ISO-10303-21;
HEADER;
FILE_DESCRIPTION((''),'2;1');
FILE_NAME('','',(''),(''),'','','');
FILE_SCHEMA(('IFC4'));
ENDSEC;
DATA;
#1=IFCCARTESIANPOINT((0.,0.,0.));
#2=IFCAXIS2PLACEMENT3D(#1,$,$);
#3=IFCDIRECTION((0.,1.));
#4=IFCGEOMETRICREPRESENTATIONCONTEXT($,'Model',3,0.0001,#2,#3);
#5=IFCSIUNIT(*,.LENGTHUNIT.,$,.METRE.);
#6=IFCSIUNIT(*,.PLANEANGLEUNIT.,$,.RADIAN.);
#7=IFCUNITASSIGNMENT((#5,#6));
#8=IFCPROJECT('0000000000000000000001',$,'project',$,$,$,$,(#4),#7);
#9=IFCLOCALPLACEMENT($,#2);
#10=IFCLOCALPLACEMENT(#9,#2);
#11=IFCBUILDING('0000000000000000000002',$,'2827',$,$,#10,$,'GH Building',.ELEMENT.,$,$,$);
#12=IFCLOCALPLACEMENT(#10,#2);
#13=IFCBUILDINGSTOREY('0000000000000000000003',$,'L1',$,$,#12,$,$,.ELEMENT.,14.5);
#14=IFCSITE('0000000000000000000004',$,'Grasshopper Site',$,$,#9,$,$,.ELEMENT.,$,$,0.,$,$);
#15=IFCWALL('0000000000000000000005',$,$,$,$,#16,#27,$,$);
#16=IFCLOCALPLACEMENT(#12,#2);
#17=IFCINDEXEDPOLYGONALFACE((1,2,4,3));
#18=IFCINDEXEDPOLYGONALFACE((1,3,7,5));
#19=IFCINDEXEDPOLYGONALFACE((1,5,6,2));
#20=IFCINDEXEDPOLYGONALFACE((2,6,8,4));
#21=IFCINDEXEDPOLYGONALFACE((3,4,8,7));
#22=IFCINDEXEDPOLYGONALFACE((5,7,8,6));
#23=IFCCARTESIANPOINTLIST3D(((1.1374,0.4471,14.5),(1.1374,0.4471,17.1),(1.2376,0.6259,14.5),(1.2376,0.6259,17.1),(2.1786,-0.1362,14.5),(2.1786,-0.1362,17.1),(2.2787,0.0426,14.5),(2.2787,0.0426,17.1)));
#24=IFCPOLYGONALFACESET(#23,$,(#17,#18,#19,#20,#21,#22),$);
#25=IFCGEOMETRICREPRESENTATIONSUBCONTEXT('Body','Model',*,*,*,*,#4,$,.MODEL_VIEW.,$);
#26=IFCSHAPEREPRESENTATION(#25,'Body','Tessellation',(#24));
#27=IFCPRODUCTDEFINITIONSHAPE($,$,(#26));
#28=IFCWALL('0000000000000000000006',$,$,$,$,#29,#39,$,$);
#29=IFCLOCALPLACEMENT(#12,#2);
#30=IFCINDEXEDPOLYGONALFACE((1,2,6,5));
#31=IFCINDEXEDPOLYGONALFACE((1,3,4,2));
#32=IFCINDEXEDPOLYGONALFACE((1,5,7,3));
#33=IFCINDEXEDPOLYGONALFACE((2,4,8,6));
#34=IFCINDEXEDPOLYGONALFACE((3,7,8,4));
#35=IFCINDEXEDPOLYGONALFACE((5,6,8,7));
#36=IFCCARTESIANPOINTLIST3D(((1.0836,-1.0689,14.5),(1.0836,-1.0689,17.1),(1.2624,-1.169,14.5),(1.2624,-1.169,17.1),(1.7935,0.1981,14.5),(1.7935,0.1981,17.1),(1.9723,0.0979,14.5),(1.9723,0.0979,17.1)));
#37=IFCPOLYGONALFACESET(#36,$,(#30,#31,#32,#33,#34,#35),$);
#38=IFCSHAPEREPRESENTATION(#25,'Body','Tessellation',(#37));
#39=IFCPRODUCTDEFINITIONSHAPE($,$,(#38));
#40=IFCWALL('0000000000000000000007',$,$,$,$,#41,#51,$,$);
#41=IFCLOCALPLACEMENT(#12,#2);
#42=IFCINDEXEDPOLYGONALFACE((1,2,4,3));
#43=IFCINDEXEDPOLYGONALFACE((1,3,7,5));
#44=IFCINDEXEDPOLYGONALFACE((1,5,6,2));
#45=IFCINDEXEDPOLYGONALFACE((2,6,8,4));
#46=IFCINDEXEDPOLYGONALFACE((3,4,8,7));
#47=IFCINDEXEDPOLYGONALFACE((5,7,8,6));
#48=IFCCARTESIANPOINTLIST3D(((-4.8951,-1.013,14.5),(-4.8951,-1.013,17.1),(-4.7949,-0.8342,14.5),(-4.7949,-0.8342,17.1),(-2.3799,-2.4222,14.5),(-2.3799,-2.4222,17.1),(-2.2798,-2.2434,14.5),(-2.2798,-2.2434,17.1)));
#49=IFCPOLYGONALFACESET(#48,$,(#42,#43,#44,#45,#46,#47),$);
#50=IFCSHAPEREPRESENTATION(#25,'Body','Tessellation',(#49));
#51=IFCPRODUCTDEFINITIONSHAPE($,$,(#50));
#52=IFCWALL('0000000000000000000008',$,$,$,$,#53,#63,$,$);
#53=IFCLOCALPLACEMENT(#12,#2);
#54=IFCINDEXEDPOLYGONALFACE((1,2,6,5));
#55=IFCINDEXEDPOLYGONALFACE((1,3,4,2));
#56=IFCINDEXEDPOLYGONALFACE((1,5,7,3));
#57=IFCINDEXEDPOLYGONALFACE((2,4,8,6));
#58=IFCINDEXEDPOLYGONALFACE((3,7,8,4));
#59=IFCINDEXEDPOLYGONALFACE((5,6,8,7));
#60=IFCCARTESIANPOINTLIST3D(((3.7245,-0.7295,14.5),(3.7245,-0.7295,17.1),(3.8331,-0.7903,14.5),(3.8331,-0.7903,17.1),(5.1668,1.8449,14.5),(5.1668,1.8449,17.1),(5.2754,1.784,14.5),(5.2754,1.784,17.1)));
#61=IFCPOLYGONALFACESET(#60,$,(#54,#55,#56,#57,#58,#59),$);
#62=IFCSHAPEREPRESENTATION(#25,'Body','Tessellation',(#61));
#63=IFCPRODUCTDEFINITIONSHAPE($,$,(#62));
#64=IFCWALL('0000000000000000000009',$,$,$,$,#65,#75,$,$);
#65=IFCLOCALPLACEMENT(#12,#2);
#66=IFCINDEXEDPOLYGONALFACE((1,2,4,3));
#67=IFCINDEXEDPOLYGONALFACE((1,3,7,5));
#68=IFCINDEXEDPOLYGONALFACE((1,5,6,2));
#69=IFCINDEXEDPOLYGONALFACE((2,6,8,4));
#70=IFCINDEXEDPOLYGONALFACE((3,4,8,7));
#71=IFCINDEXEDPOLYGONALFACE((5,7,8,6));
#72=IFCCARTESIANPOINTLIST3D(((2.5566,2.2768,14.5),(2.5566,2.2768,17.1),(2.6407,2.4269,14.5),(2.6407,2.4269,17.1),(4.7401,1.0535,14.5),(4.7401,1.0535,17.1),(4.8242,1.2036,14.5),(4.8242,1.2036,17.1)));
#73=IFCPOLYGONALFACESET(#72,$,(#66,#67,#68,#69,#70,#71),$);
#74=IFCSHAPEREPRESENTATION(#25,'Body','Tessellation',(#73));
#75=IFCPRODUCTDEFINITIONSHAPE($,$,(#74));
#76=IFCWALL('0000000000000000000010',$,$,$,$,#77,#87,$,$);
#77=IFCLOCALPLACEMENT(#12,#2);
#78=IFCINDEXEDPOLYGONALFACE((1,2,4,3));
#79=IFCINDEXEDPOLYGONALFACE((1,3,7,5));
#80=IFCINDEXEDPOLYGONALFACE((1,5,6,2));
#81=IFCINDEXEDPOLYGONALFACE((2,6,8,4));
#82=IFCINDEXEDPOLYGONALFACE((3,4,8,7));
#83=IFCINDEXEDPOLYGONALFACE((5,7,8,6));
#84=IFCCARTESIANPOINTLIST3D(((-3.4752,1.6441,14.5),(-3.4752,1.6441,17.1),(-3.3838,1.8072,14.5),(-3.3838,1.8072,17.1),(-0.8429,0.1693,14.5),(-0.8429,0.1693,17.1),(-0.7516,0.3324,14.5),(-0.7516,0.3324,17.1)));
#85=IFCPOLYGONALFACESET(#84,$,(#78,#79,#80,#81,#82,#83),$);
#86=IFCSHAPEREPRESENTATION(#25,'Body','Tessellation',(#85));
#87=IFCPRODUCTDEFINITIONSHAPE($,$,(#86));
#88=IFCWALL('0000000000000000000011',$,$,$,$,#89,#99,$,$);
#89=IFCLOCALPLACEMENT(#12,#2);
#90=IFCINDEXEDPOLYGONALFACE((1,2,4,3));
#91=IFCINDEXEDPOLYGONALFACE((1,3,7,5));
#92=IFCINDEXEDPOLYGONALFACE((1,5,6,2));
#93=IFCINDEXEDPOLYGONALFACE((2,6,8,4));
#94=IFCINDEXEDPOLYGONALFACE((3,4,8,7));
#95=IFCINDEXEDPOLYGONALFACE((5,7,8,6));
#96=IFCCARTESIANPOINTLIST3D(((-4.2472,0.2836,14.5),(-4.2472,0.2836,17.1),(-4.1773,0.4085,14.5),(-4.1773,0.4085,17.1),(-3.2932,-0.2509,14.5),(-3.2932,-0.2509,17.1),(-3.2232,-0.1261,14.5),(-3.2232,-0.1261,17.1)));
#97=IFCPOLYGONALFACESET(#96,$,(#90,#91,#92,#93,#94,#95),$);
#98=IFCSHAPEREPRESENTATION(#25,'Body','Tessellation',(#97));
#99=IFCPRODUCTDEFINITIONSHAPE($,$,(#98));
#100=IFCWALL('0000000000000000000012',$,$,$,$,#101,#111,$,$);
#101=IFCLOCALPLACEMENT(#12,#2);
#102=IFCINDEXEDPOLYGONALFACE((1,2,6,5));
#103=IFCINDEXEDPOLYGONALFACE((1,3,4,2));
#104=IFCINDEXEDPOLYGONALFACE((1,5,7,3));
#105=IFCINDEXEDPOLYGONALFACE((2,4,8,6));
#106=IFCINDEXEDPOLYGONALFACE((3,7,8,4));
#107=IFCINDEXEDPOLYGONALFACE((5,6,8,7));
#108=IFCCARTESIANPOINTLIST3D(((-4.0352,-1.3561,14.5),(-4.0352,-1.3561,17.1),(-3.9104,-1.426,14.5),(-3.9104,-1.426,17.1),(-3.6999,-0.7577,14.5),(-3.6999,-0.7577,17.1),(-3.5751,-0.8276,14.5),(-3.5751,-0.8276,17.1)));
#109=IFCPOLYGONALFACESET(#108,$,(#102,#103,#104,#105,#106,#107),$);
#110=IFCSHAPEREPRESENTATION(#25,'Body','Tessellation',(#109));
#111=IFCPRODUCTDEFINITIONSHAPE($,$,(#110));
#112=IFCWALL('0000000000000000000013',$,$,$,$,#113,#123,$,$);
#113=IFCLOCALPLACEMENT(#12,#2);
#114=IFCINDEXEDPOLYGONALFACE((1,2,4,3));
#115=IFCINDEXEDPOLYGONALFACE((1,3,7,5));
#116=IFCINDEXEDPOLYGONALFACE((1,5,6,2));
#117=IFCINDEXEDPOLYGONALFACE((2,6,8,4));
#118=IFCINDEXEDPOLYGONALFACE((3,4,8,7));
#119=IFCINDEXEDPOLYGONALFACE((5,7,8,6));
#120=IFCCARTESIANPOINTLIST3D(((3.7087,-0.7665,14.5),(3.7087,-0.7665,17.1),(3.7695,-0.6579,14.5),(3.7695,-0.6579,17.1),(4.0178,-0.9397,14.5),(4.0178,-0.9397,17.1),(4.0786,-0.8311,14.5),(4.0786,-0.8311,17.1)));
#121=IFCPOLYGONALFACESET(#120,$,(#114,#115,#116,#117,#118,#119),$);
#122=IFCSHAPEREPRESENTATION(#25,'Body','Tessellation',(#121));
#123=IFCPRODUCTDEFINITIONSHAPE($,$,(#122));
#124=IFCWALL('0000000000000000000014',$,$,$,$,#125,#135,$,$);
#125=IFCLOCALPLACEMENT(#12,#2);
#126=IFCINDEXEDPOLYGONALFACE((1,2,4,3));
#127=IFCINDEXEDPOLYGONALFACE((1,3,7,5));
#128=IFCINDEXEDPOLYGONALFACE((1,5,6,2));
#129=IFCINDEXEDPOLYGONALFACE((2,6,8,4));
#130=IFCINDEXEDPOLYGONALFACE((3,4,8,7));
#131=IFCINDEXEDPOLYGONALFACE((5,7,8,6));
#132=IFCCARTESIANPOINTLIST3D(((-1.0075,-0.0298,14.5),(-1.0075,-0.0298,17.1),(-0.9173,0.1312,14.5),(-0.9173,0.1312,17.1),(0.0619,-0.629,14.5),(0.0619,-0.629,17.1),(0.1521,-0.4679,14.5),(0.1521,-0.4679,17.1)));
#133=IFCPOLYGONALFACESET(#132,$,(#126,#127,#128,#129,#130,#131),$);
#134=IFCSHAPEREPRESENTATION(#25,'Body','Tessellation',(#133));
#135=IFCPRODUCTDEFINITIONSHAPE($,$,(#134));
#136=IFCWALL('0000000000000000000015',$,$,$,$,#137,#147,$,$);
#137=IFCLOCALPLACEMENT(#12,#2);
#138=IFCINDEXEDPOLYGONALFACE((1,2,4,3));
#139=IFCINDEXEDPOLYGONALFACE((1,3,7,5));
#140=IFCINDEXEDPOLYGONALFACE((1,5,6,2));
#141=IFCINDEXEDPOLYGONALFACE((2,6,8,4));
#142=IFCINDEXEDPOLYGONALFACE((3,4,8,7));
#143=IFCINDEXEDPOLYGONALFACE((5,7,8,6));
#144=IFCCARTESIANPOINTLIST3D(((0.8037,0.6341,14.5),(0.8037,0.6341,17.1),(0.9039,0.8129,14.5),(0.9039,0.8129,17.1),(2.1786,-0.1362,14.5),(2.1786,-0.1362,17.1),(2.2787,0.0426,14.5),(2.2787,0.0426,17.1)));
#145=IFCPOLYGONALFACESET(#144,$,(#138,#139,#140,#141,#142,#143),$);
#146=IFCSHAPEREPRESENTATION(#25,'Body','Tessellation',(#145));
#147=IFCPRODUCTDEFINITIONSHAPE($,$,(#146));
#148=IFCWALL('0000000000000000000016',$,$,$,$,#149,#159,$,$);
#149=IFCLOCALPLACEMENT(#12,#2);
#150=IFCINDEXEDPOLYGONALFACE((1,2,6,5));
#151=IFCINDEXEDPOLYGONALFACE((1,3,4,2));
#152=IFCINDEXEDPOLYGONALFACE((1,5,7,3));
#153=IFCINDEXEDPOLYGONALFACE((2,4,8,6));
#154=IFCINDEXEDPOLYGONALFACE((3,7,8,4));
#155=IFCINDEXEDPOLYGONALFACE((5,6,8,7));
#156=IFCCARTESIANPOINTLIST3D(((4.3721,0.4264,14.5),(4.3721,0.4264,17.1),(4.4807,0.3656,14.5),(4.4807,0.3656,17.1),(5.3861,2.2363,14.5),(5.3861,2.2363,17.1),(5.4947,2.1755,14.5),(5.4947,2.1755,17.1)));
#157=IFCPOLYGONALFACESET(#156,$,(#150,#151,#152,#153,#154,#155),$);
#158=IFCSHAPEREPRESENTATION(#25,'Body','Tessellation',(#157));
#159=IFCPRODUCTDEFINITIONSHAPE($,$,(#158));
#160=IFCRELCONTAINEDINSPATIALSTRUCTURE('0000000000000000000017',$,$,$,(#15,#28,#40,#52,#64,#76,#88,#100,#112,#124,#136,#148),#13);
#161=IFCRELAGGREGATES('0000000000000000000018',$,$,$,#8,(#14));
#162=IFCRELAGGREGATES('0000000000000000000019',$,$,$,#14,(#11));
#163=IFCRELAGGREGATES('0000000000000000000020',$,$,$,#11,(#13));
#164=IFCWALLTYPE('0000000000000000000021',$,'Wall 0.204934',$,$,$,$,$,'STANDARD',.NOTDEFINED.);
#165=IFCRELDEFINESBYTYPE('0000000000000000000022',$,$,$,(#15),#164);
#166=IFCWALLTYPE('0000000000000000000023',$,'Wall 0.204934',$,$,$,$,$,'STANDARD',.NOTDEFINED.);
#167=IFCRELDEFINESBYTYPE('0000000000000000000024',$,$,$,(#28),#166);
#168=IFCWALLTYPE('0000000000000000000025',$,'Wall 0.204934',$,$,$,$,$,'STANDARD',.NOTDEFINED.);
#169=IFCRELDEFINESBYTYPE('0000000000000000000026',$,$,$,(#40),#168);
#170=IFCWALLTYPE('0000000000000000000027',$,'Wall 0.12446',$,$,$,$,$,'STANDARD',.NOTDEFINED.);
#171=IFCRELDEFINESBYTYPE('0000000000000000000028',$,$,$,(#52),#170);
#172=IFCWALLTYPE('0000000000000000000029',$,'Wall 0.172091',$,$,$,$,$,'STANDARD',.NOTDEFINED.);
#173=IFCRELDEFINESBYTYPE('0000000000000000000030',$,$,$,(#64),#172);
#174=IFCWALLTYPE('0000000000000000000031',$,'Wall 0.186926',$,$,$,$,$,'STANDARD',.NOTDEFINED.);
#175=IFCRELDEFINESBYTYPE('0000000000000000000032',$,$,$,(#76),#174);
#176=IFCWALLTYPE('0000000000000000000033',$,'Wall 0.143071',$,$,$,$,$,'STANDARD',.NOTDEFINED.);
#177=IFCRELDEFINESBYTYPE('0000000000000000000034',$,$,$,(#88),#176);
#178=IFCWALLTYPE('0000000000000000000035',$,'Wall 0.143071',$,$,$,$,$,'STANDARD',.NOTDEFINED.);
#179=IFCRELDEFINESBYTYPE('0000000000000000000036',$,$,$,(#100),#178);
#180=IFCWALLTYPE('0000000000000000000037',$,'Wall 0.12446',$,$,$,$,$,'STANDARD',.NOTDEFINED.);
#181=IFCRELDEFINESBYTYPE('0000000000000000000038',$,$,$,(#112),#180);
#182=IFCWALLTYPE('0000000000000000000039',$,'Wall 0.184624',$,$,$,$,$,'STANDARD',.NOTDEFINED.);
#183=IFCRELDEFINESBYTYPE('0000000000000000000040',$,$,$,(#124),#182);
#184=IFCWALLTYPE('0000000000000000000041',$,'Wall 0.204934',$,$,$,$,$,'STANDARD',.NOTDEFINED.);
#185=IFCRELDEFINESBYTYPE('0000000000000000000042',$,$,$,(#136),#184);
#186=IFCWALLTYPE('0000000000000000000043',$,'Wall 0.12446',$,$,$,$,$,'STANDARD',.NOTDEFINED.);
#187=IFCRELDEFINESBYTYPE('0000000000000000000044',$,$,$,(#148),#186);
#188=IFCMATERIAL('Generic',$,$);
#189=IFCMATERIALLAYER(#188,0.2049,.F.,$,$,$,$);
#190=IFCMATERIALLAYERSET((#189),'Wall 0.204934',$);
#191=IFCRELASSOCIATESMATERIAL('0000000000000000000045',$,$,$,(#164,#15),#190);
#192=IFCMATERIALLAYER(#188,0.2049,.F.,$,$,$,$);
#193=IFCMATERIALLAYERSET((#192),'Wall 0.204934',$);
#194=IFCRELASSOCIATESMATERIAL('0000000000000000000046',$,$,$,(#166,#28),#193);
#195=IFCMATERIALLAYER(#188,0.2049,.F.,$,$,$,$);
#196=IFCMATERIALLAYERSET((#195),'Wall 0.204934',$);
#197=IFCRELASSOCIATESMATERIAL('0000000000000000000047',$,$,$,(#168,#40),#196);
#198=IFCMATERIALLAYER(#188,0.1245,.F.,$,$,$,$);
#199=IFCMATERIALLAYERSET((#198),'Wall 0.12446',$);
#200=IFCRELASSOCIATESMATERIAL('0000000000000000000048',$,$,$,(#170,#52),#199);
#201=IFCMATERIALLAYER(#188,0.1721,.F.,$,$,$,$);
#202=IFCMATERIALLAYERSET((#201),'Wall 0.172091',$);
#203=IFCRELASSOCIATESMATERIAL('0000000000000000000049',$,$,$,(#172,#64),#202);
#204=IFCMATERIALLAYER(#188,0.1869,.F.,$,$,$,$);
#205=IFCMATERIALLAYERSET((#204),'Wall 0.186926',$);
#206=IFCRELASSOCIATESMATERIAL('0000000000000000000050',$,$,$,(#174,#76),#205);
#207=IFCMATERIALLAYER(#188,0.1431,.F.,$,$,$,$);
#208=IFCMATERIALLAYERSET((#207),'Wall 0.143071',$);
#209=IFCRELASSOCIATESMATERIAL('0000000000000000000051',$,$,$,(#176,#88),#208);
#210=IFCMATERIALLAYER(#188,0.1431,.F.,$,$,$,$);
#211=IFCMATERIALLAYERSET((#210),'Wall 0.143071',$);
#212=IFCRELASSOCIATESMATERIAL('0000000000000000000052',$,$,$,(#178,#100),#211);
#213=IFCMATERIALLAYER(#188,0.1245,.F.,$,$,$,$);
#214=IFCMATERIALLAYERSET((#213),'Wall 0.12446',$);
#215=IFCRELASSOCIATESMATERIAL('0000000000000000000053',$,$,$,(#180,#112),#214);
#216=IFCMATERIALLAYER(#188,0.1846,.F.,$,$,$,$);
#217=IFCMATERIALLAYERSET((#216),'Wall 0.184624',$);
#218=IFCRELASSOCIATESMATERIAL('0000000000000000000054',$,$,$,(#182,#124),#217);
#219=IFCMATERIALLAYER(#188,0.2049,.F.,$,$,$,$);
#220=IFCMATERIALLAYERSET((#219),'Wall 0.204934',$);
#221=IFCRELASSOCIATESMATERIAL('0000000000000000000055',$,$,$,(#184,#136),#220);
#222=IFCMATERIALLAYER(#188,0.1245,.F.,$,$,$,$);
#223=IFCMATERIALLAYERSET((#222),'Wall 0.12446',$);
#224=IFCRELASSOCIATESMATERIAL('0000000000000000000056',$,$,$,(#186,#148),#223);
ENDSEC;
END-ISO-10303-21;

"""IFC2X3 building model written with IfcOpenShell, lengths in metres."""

from ifc_helpers import new_model, si_unit, direction, frame, frame_2d, origin, place, context, subcontext, project, spatial, rectangle, extrude, material, layer, layer_set, layer_usage, type_object, element, save


model = new_model("IFC2X3")

# Units and contexts
model_context = context("Model", 3, precision=0.0001, world=origin(), true_north=direction((0.0, 1.0)))
body_context = subcontext(model_context, "Body", "Model", "MODEL_VIEW")
ifc_project = project(units=[si_unit("LENGTHUNIT", "METRE"), si_unit("PLANEANGLEUNIT", "RADIAN")], contexts=[model_context])

# Site, building, storey
site_placement = place(None, origin())
site = spatial("IfcSite", under=ifc_project, at=site_placement, Name="Grasshopper Site", CompositionType="ELEMENT", RefElevation=0.0)
building_placement = place(site_placement, origin())
building = spatial("IfcBuilding", under=site, at=building_placement, Name="2827", LongName="GH Building", CompositionType="ELEMENT")
storey_placement = place(building_placement, origin())
storey = spatial("IfcBuildingStorey", under=building, at=storey_placement, Name="L1", CompositionType="ELEMENT", Elevation=14.5)

# Wall
ifc_material = material(Name="Generic")
ifc_layer_1 = layer(ifc_material, 0.2049, ventilated=False)
ifc_layer_set_1 = layer_set([ifc_layer_1], Name="Wall 0.204934")
ifc_layer_usage_1 = layer_usage(ifc_layer_set_1, "AXIS2", "NEGATIVE", 0.1025)
wall_type_1 = type_object("IfcWallType", Name="Wall 0.204934", ElementType="STANDARD", PredefinedType="NOTDEFINED", material=ifc_layer_set_1)
wall_1_placement = place(storey_placement, frame((1.1875, 0.5365, 14.5), z_axis=(0.0, 0.0, 1.0), x_axis=(0.872406, -0.488782, 0.0)))
element("IfcWall", 1, at=wall_1_placement, inside=storey, type_object=wall_type_1, material=ifc_layer_usage_1, context=body_context, shape_type="SweptSolid", body=[
    extrude(rectangle(XDim=1.1934, YDim=0.2049, at=frame_2d((0.5967, 0.0))), origin(), (0.0, 0.0, 1.0), 2.6),
])

# Walls
ifc_layer_2 = layer(ifc_material, 0.2049, ventilated=False)
ifc_layer_set_2 = layer_set([ifc_layer_2], Name="Wall 0.204934")
ifc_layer_usage_2 = layer_usage(ifc_layer_set_2, "AXIS2", "NEGATIVE", 0.1025)
wall_type_2 = type_object("IfcWallType", Name="Wall 0.204934", ElementType="STANDARD", PredefinedType="NOTDEFINED", material=ifc_layer_set_2)
wall_2_placement = place(storey_placement, frame((1.8829, 0.148, 14.5), z_axis=(0.0, 0.0, 1.0), x_axis=(-0.488782, -0.872406, 0.0)))
element("IfcWall", 2, at=wall_2_placement, inside=storey, type_object=wall_type_2, material=ifc_layer_usage_2, context=body_context, shape_type="SweptSolid", body=[
    extrude(rectangle(XDim=1.4523, YDim=0.2049, at=frame_2d((0.7261, 0.0))), origin(), (0.0, 0.0, 1.0), 2.6),
])
ifc_layer_3 = layer(ifc_material, 0.2049, ventilated=False)
ifc_layer_set_3 = layer_set([ifc_layer_3], Name="Wall 0.204934")
ifc_layer_usage_3 = layer_usage(ifc_layer_set_3, "AXIS2", "NEGATIVE", 0.1025)
wall_type_3 = type_object("IfcWallType", Name="Wall 0.204934", ElementType="STANDARD", PredefinedType="NOTDEFINED", material=ifc_layer_set_3)
wall_3_placement = place(storey_placement, frame((-4.845, -0.9236, 14.5), z_axis=(0.0, 0.0, 1.0), x_axis=(0.872406, -0.488782, 0.0)))
element("IfcWall", 3, at=wall_3_placement, inside=storey, type_object=wall_type_3, material=ifc_layer_usage_3, context=body_context, shape_type="SweptSolid", body=[
    extrude(rectangle(XDim=2.883, YDim=0.2049, at=frame_2d((1.4415, 0.0))), origin(), (0.0, 0.0, 1.0), 2.6),
])

# Wall
ifc_layer_4 = layer(ifc_material, 0.1245, ventilated=False)
ifc_layer_set_4 = layer_set([ifc_layer_4], Name="Wall 0.12446")
ifc_layer_usage_4 = layer_usage(ifc_layer_set_4, "AXIS2", "NEGATIVE", 0.0622)
wall_type_4 = type_object("IfcWallType", Name="Wall 0.12446", ElementType="STANDARD", PredefinedType="NOTDEFINED", material=ifc_layer_set_4)
wall_4_placement = place(storey_placement, frame((3.7788, -0.7599, 14.5), z_axis=(0.0, 0.0, 1.0), x_axis=(0.488782, 0.872406, 0.0)))
element("IfcWall", 4, at=wall_4_placement, inside=storey, type_object=wall_type_4, material=ifc_layer_usage_4, context=body_context, shape_type="SweptSolid", body=[
    extrude(rectangle(XDim=2.9508, YDim=0.1245, at=frame_2d((1.4754, 0.0))), origin(), (0.0, 0.0, 1.0), 2.6),
])

# Walls
ifc_layer_5 = layer(ifc_material, 0.1721, ventilated=False)
ifc_layer_set_5 = layer_set([ifc_layer_5], Name="Wall 0.172091")
ifc_layer_usage_5 = layer_usage(ifc_layer_set_5, "AXIS2", "NEGATIVE", 0.086)
wall_type_5 = type_object("IfcWallType", Name="Wall 0.172091", ElementType="STANDARD", PredefinedType="NOTDEFINED", material=ifc_layer_set_5)
wall_5_placement = place(storey_placement, frame((4.7821, 1.1285, 14.5), z_axis=(0.0, 0.0, 1.0), x_axis=(-0.872406, 0.488782, 0.0)))
element("IfcWall", 5, at=wall_5_placement, inside=storey, type_object=wall_type_5, material=ifc_layer_usage_5, context=body_context, shape_type="SweptSolid", body=[
    extrude(rectangle(XDim=2.5028, YDim=0.1721, at=frame_2d((1.2514, 0.0))), origin(), (0.0, 0.0, 1.0), 2.6),
])
ifc_layer_6 = layer(ifc_material, 0.1869, ventilated=False)
ifc_layer_set_6 = layer_set([ifc_layer_6], Name="Wall 0.186926")
ifc_layer_usage_6 = layer_usage(ifc_layer_set_6, "AXIS2", "NEGATIVE", 0.0935)
wall_type_6 = type_object("IfcWallType", Name="Wall 0.186926", ElementType="STANDARD", PredefinedType="NOTDEFINED", material=ifc_layer_set_6)
wall_6_placement = place(storey_placement, frame((-0.7973, 0.2509, 14.5), z_axis=(0.0, 0.0, 1.0), x_axis=(-0.872406, 0.488782, 0.0)))
element("IfcWall", 6, at=wall_6_placement, inside=storey, type_object=wall_type_6, material=ifc_layer_usage_6, context=body_context, shape_type="SweptSolid", body=[
    extrude(rectangle(XDim=3.0172, YDim=0.1869, at=frame_2d((1.5086, 0.0))), origin(), (0.0, 0.0, 1.0), 2.6),
])
ifc_layer_7 = layer(ifc_material, 0.1431, ventilated=False)
ifc_layer_set_7 = layer_set([ifc_layer_7], Name="Wall 0.143071")
ifc_layer_usage_7 = layer_usage(ifc_layer_set_7, "AXIS2", "NEGATIVE", 0.0715)
wall_type_7 = type_object("IfcWallType", Name="Wall 0.143071", ElementType="STANDARD", PredefinedType="NOTDEFINED", material=ifc_layer_set_7)
wall_7_placement = place(storey_placement, frame((-4.2123, 0.3461, 14.5), z_axis=(0.0, 0.0, 1.0), x_axis=(0.872406, -0.488782, 0.0)))
element("IfcWall", 7, at=wall_7_placement, inside=storey, type_object=wall_type_7, material=ifc_layer_usage_7, context=body_context, shape_type="SweptSolid", body=[
    extrude(rectangle(XDim=1.0936, YDim=0.1431, at=frame_2d((0.5468, 0.0))), origin(), (0.0, 0.0, 1.0), 2.6),
])
ifc_layer_8 = layer(ifc_material, 0.1431, ventilated=False)
ifc_layer_set_8 = layer_set([ifc_layer_8], Name="Wall 0.143071")
ifc_layer_usage_8 = layer_usage(ifc_layer_set_8, "AXIS2", "NEGATIVE", 0.0715)
wall_type_8 = type_object("IfcWallType", Name="Wall 0.143071", ElementType="STANDARD", PredefinedType="NOTDEFINED", material=ifc_layer_set_8)
wall_8_placement = place(storey_placement, frame((-3.6375, -0.7927, 14.5), z_axis=(0.0, 0.0, 1.0), x_axis=(-0.488782, -0.872406, 0.0)))
element("IfcWall", 8, at=wall_8_placement, inside=storey, type_object=wall_type_8, material=ifc_layer_usage_8, context=body_context, shape_type="SweptSolid", body=[
    extrude(rectangle(XDim=0.6859, YDim=0.1431, at=frame_2d((0.343, 0.0))), origin(), (0.0, 0.0, 1.0), 2.6),
])

# Walls
ifc_layer_9 = layer(ifc_material, 0.1245, ventilated=False)
ifc_layer_set_9 = layer_set([ifc_layer_9], Name="Wall 0.12446")
ifc_layer_usage_9 = layer_usage(ifc_layer_set_9, "AXIS2", "NEGATIVE", 0.0622)
wall_type_9 = type_object("IfcWallType", Name="Wall 0.12446", ElementType="STANDARD", PredefinedType="NOTDEFINED", material=ifc_layer_set_9)
wall_9_placement = place(storey_placement, frame((3.7391, -0.7122, 14.5), z_axis=(0.0, 0.0, 1.0), x_axis=(0.872406, -0.488782, 0.0)))
element("IfcWall", 9, at=wall_9_placement, inside=storey, type_object=wall_type_9, material=ifc_layer_usage_9, context=body_context, shape_type="SweptSolid", body=[
    extrude(rectangle(XDim=0.3544, YDim=0.1245, at=frame_2d((0.1772, 0.0))), origin(), (0.0, 0.0, 1.0), 2.6),
])
ifc_layer_10 = layer(ifc_material, 0.1846, ventilated=False)
ifc_layer_set_10 = layer_set([ifc_layer_10], Name="Wall 0.184624")
ifc_layer_usage_10 = layer_usage(ifc_layer_set_10, "AXIS2", "NEGATIVE", 0.0923)
wall_type_10 = type_object("IfcWallType", Name="Wall 0.184624", ElementType="STANDARD", PredefinedType="NOTDEFINED", material=ifc_layer_set_10)
wall_10_placement = place(storey_placement, frame((0.107, -0.5484, 14.5), z_axis=(0.0, 0.0, 1.0), x_axis=(-0.872406, 0.488782, 0.0)))
element("IfcWall", 10, at=wall_10_placement, inside=storey, type_object=wall_type_10, material=ifc_layer_usage_10, context=body_context, shape_type="SweptSolid", body=[
    extrude(rectangle(XDim=1.2258, YDim=0.1846, at=frame_2d((0.6129, 0.0))), origin(), (0.0, 0.0, 1.0), 2.6),
])

# Walls
ifc_layer_11 = layer(ifc_material, 0.2049, ventilated=False)
ifc_layer_set_11 = layer_set([ifc_layer_11], Name="Wall 0.204934")
ifc_layer_usage_11 = layer_usage(ifc_layer_set_11, "AXIS2", "NEGATIVE", 0.1025)
wall_type_11 = type_object("IfcWallType", Name="Wall 0.204934", ElementType="STANDARD", PredefinedType="NOTDEFINED", material=ifc_layer_set_11)
wall_11_placement = place(storey_placement, frame((0.8538, 0.7235, 14.5), z_axis=(0.0, 0.0, 1.0), x_axis=(0.872406, -0.488782, 0.0)))
element("IfcWall", 11, at=wall_11_placement, inside=storey, type_object=wall_type_11, material=ifc_layer_usage_11, context=body_context, shape_type="SweptSolid", body=[
    extrude(rectangle(XDim=1.5759, YDim=0.2049, at=frame_2d((0.788, 0.0))), origin(), (0.0, 0.0, 1.0), 2.6),
])
ifc_layer_12 = layer(ifc_material, 0.1245, ventilated=False)
ifc_layer_set_12 = layer_set([ifc_layer_12], Name="Wall 0.12446")
ifc_layer_usage_12 = layer_usage(ifc_layer_set_12, "AXIS2", "NEGATIVE", 0.0622)
wall_type_12 = type_object("IfcWallType", Name="Wall 0.12446", ElementType="STANDARD", PredefinedType="NOTDEFINED", material=ifc_layer_set_12)
wall_12_placement = place(storey_placement, frame((4.4264, 0.396, 14.5), z_axis=(0.0, 0.0, 1.0), x_axis=(0.488782, 0.872406, 0.0)))
element("IfcWall", 12, at=wall_12_placement, inside=storey, type_object=wall_type_12, material=ifc_layer_usage_12, context=body_context, shape_type="SweptSolid", body=[
    extrude(rectangle(XDim=2.0746, YDim=0.1245, at=frame_2d((1.0373, 0.0))), origin(), (0.0, 0.0, 1.0), 2.6),
])

save(model, "model.ifc")
